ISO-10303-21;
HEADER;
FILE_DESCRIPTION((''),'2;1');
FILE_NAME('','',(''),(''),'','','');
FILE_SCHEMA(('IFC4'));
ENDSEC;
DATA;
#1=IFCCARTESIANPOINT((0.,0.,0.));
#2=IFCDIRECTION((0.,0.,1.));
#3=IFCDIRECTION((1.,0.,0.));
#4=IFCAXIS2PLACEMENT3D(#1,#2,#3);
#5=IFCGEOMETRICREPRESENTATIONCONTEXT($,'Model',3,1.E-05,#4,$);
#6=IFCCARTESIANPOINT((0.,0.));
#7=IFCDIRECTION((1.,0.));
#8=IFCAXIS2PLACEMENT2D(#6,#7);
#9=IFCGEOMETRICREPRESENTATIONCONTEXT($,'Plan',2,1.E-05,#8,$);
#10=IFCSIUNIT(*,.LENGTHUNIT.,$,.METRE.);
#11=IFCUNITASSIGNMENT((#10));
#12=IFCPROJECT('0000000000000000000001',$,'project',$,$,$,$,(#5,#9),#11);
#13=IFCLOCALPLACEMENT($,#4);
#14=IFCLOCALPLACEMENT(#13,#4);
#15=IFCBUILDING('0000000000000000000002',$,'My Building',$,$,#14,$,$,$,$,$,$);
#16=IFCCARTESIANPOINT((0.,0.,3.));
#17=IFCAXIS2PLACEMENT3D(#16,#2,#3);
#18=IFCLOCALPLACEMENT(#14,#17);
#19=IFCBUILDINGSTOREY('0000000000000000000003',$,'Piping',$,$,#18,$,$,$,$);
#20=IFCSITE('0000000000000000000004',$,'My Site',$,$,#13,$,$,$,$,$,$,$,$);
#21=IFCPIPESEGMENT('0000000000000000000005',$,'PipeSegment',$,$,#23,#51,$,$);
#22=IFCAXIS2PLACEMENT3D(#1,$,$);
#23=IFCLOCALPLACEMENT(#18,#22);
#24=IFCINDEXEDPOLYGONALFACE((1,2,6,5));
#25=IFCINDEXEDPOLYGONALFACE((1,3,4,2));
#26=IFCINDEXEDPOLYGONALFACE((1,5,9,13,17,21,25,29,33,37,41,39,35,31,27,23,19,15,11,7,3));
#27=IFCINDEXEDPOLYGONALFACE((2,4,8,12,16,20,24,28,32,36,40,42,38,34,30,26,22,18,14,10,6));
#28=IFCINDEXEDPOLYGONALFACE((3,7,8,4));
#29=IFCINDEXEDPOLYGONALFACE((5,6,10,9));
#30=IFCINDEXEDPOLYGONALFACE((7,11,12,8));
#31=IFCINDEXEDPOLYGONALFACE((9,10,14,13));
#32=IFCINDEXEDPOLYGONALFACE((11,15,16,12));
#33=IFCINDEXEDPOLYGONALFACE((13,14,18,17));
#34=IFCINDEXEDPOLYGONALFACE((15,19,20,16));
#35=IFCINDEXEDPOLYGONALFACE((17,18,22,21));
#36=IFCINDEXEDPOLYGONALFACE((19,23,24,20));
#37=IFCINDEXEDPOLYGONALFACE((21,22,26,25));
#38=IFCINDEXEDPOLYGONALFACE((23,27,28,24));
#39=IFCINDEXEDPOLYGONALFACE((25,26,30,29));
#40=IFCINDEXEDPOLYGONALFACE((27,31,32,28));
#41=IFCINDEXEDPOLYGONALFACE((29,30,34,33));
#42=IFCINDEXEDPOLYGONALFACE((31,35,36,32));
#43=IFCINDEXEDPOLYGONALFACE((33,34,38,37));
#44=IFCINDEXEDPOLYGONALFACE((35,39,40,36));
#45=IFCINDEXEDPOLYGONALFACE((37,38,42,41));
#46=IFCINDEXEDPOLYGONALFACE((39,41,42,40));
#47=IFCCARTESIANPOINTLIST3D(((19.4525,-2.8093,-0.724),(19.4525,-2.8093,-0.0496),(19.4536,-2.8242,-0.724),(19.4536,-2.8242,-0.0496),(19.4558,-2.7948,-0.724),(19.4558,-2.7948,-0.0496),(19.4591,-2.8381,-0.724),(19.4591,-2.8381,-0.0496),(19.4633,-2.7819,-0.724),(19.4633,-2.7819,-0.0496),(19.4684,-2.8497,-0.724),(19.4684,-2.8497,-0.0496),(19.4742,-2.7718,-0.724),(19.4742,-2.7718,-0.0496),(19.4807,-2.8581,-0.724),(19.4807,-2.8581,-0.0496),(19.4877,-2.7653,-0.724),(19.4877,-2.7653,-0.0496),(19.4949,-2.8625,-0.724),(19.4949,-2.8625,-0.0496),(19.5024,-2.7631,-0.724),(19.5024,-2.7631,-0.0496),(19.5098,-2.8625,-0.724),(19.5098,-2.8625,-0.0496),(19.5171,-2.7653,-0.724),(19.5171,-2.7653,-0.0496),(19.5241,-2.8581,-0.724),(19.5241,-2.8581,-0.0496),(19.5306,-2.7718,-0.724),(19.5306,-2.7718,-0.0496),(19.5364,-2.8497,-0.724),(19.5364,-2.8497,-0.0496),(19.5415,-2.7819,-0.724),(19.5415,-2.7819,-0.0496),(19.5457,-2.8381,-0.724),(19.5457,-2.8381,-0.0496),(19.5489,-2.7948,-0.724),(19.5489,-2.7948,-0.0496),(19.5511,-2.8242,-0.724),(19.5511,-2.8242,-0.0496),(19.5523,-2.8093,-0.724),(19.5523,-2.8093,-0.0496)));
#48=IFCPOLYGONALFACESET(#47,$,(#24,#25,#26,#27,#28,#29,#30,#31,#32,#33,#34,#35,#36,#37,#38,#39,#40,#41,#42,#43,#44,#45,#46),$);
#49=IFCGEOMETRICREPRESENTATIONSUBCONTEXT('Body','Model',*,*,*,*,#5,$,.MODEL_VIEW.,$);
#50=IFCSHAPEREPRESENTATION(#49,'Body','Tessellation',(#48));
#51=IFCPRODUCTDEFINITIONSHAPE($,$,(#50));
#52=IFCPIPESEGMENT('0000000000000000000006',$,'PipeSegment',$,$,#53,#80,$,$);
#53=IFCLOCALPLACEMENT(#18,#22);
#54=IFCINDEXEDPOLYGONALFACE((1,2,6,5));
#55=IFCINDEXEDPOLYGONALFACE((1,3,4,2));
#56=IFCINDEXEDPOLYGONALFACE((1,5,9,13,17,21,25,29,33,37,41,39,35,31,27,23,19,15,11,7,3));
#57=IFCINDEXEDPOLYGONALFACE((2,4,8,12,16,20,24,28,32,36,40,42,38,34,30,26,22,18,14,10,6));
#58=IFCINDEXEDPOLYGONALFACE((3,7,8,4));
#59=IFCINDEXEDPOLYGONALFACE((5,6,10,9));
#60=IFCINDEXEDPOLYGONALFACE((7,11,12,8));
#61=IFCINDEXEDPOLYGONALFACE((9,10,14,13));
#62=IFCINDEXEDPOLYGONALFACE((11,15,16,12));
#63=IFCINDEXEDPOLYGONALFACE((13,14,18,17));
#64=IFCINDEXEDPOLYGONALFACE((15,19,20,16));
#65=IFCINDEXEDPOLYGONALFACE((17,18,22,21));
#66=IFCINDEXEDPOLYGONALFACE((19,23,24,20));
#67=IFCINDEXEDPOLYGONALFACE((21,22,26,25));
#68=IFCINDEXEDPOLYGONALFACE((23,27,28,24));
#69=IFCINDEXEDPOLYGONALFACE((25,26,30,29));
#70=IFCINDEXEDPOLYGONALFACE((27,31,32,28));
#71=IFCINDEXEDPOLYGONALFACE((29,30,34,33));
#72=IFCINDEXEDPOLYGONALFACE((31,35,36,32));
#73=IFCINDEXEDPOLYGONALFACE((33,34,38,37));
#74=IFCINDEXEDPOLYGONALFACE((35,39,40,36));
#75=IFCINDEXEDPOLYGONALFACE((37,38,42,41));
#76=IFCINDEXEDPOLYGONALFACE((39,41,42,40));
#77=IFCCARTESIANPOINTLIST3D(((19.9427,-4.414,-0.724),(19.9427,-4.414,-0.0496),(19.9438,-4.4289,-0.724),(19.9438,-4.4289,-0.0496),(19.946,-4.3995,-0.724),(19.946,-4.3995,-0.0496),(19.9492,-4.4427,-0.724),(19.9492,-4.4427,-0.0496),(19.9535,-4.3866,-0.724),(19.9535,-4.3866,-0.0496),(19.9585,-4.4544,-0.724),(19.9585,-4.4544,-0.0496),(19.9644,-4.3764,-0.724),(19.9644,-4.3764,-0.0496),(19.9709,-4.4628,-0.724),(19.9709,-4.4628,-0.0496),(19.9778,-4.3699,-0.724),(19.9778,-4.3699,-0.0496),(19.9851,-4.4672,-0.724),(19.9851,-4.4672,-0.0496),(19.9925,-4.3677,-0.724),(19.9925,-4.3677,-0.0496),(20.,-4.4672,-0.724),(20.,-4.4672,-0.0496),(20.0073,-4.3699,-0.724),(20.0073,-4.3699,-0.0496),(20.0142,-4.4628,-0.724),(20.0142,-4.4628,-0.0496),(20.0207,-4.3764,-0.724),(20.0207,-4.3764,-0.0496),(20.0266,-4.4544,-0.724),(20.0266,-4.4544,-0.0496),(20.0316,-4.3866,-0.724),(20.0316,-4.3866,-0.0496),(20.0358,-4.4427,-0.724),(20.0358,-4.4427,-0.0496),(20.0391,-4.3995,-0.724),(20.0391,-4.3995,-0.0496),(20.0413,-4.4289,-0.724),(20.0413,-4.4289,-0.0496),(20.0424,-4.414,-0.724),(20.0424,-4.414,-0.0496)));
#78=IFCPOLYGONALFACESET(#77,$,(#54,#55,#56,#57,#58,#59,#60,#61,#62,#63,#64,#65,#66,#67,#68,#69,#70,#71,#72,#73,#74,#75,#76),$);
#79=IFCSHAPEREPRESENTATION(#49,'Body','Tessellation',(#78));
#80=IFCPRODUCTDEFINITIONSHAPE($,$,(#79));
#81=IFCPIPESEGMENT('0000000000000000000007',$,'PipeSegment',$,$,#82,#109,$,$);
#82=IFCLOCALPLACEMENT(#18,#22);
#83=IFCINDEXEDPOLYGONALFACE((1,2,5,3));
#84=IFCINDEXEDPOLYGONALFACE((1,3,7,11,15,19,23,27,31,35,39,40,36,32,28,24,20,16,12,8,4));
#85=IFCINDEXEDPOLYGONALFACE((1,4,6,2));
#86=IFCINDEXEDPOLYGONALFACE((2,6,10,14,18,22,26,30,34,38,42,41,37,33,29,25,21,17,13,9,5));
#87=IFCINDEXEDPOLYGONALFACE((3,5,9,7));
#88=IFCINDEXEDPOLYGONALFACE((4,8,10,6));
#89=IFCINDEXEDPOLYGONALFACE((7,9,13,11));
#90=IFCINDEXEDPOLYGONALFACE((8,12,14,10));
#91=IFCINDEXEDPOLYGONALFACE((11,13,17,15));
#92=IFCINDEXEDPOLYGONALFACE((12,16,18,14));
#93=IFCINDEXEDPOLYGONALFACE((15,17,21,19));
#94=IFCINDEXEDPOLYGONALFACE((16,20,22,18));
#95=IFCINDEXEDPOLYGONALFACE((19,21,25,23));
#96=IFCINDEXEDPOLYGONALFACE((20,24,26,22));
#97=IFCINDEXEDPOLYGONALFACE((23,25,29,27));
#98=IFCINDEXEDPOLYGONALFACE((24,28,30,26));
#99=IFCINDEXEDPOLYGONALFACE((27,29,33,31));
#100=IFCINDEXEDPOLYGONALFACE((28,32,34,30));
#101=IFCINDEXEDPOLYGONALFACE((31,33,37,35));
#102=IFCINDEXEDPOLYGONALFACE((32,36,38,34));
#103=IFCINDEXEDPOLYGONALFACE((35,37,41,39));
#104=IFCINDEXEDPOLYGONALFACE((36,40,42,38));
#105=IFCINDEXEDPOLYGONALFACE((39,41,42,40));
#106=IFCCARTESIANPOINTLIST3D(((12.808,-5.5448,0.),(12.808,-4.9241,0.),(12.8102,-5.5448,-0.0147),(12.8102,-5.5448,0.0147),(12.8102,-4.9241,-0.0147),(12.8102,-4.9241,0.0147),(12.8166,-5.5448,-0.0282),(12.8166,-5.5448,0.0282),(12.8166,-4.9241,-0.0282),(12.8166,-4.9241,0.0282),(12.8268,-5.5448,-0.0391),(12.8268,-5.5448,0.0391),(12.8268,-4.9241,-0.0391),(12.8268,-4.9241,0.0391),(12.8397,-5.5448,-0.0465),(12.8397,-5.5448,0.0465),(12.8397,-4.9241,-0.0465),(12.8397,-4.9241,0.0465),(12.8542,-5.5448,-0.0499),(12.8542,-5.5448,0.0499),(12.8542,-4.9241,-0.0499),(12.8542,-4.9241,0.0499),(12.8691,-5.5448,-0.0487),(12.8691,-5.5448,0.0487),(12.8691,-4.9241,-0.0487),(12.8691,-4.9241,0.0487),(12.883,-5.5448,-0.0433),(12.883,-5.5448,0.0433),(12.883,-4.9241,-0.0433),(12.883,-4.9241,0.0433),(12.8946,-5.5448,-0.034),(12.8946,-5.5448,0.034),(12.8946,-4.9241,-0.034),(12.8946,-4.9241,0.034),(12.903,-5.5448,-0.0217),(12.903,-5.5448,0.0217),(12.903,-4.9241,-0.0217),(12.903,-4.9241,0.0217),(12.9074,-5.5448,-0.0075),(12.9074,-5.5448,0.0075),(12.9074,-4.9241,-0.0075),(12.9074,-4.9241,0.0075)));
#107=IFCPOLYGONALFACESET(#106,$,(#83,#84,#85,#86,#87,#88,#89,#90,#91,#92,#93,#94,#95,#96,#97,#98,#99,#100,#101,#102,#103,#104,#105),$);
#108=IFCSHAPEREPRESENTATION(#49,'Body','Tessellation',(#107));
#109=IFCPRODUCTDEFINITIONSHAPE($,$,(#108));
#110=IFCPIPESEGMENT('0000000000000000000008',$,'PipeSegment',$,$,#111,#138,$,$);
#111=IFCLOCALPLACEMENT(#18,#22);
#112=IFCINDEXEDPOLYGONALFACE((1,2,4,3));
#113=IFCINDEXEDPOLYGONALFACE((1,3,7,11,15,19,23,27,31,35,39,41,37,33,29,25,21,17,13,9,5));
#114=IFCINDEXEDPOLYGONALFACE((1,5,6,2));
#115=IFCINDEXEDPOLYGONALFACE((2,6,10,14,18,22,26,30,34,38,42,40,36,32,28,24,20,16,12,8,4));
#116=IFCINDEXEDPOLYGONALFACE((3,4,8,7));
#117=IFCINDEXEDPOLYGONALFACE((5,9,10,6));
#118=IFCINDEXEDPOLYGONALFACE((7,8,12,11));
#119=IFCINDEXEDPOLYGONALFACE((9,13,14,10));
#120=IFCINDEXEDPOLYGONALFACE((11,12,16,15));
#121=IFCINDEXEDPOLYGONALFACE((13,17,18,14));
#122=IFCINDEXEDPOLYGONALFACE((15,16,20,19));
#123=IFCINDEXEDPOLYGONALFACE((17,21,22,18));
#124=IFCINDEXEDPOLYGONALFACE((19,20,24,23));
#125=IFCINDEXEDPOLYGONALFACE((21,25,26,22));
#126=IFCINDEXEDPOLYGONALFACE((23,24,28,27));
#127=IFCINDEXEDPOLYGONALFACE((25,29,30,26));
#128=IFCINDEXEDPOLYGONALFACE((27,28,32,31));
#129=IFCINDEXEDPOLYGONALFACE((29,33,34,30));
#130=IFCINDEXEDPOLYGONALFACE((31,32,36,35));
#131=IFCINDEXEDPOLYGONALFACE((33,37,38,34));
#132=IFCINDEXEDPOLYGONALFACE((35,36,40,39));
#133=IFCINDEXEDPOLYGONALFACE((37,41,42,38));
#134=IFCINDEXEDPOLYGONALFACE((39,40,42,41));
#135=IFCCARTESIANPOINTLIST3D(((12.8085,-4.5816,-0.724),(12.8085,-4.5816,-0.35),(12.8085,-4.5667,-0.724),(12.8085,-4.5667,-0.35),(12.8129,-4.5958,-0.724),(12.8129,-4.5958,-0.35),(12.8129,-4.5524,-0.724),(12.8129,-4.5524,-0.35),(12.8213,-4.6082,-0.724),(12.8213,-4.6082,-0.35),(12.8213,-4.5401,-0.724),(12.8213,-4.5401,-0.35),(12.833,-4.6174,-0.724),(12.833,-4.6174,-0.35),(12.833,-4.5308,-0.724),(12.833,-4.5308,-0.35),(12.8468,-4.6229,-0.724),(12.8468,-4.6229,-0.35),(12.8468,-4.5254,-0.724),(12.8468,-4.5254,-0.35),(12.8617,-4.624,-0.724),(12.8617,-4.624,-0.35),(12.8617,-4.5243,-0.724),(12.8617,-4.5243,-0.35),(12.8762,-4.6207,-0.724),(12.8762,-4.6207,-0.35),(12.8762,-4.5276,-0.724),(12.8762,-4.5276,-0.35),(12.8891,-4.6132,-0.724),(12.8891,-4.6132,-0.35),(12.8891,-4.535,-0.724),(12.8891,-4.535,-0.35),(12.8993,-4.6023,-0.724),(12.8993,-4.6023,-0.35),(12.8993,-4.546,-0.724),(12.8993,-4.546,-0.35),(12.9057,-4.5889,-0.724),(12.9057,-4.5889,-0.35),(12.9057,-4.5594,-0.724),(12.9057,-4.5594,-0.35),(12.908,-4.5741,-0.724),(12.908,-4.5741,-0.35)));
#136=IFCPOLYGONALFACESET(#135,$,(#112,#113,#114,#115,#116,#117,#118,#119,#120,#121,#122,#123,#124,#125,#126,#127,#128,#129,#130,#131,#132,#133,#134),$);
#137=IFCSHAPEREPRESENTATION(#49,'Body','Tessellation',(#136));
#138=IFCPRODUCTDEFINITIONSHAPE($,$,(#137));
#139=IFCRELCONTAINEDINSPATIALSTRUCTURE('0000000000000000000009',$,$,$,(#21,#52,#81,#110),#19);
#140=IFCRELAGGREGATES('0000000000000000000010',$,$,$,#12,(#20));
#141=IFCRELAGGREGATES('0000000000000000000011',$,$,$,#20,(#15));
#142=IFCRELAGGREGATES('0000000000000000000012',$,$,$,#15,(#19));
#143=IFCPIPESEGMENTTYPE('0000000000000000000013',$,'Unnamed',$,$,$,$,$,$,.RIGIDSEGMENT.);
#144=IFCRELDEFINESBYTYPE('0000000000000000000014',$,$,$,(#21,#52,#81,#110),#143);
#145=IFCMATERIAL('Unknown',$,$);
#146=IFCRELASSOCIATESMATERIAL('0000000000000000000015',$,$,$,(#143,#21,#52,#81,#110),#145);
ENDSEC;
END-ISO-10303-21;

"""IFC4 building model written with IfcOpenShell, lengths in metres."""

from ifc_helpers import new_model, si_unit, frame, origin_with_axes, origin_2d_with_axis, place, context, subcontext, project, spatial, circle, extrude, material, material_profile, profile_set, profile_usage, type_object, element, save


model = new_model("IFC4")

# Units and contexts
model_context = context("Model", 3, precision=1e-05, world=origin_with_axes())
plan_context = context("Plan", 2, precision=1e-05, world=origin_2d_with_axis())
body_context = subcontext(model_context, "Body", "Model", "MODEL_VIEW")
ifc_project = project(units=[si_unit("LENGTHUNIT", "METRE")], contexts=[model_context, plan_context])

# Site, building, storey
site_placement = place(None, origin_with_axes())
site = spatial("IfcSite", under=ifc_project, at=site_placement, Name="My Site")
building_placement = place(site_placement, origin_with_axes())
building = spatial("IfcBuilding", under=site, at=building_placement, Name="My Building")
storey_placement = place(building_placement, frame((0.0, 0.0, 3.0), z_axis=(0.0, 0.0, 1.0), x_axis=(1.0, 0.0, 0.0)))
storey = spatial("IfcBuildingStorey", under=building, at=storey_placement, Name="Piping")

# Pipe segments
ifc_material = material(Name="Unknown")
ifc_material_profile = material_profile(ifc_material, circle(Radius=0.05))
ifc_profile_set = profile_set([ifc_material_profile])
pipe_segment_type = type_object("IfcPipeSegmentType", Name="Unnamed", PredefinedType="RIGIDSEGMENT", material=ifc_profile_set)
ifc_profile_usage_1 = profile_usage(ifc_profile_set, cardinal=5)
pipe_segment_1_placement = place(storey_placement, frame((19.5024, -2.8131, -0.0496), z_axis=(0.0, 0.0, -1.0), x_axis=(0.0, 1.0, 0.0)))
element("IfcPipeSegment", 1, at=pipe_segment_1_placement, inside=storey, type_object=pipe_segment_type, material=ifc_profile_usage_1, Name="PipeSegment", context=body_context, shape_type="SweptSolid", body=[
    extrude(circle(Radius=0.05), origin_with_axes(), (0.0, 0.0, 1.0), 0.6743),
])
ifc_profile_usage_2 = profile_usage(ifc_profile_set, cardinal=5)
pipe_segment_2_placement = place(storey_placement, frame((19.9925, -4.4177, -0.0496), z_axis=(0.0, 0.0, -1.0), x_axis=(0.0, 1.0, 0.0)))
element("IfcPipeSegment", 2, at=pipe_segment_2_placement, inside=storey, type_object=pipe_segment_type, material=ifc_profile_usage_2, Name="PipeSegment", context=body_context, shape_type="SweptSolid", body=[
    extrude(circle(Radius=0.05), origin_with_axes(), (0.0, 0.0, 1.0), 0.6743),
])
ifc_profile_usage_3 = profile_usage(ifc_profile_set, cardinal=5)
pipe_segment_3_placement = place(storey_placement, frame((12.858, -5.5448, 0.0), z_axis=(0.0, 1.0, 0.0), x_axis=(-1.0, 0.0, 0.0)))
element("IfcPipeSegment", 3, at=pipe_segment_3_placement, inside=storey, type_object=pipe_segment_type, material=ifc_profile_usage_3, Name="PipeSegment", context=body_context, shape_type="SweptSolid", body=[
    extrude(circle(Radius=0.05), origin_with_axes(), (0.0, 0.0, 1.0), 0.6207),
])
ifc_profile_usage_4 = profile_usage(ifc_profile_set, cardinal=5)
pipe_segment_4_placement = place(storey_placement, frame((12.858, -4.5741, -0.35), z_axis=(0.0, 0.0, -1.0), x_axis=(1.0, 0.0, 0.0)))
element("IfcPipeSegment", 4, at=pipe_segment_4_placement, inside=storey, type_object=pipe_segment_type, material=ifc_profile_usage_4, Name="PipeSegment", context=body_context, shape_type="SweptSolid", body=[
    extrude(circle(Radius=0.05), origin_with_axes(), (0.0, 0.0, 1.0), 0.374),
])

save(model, "model.ifc")
